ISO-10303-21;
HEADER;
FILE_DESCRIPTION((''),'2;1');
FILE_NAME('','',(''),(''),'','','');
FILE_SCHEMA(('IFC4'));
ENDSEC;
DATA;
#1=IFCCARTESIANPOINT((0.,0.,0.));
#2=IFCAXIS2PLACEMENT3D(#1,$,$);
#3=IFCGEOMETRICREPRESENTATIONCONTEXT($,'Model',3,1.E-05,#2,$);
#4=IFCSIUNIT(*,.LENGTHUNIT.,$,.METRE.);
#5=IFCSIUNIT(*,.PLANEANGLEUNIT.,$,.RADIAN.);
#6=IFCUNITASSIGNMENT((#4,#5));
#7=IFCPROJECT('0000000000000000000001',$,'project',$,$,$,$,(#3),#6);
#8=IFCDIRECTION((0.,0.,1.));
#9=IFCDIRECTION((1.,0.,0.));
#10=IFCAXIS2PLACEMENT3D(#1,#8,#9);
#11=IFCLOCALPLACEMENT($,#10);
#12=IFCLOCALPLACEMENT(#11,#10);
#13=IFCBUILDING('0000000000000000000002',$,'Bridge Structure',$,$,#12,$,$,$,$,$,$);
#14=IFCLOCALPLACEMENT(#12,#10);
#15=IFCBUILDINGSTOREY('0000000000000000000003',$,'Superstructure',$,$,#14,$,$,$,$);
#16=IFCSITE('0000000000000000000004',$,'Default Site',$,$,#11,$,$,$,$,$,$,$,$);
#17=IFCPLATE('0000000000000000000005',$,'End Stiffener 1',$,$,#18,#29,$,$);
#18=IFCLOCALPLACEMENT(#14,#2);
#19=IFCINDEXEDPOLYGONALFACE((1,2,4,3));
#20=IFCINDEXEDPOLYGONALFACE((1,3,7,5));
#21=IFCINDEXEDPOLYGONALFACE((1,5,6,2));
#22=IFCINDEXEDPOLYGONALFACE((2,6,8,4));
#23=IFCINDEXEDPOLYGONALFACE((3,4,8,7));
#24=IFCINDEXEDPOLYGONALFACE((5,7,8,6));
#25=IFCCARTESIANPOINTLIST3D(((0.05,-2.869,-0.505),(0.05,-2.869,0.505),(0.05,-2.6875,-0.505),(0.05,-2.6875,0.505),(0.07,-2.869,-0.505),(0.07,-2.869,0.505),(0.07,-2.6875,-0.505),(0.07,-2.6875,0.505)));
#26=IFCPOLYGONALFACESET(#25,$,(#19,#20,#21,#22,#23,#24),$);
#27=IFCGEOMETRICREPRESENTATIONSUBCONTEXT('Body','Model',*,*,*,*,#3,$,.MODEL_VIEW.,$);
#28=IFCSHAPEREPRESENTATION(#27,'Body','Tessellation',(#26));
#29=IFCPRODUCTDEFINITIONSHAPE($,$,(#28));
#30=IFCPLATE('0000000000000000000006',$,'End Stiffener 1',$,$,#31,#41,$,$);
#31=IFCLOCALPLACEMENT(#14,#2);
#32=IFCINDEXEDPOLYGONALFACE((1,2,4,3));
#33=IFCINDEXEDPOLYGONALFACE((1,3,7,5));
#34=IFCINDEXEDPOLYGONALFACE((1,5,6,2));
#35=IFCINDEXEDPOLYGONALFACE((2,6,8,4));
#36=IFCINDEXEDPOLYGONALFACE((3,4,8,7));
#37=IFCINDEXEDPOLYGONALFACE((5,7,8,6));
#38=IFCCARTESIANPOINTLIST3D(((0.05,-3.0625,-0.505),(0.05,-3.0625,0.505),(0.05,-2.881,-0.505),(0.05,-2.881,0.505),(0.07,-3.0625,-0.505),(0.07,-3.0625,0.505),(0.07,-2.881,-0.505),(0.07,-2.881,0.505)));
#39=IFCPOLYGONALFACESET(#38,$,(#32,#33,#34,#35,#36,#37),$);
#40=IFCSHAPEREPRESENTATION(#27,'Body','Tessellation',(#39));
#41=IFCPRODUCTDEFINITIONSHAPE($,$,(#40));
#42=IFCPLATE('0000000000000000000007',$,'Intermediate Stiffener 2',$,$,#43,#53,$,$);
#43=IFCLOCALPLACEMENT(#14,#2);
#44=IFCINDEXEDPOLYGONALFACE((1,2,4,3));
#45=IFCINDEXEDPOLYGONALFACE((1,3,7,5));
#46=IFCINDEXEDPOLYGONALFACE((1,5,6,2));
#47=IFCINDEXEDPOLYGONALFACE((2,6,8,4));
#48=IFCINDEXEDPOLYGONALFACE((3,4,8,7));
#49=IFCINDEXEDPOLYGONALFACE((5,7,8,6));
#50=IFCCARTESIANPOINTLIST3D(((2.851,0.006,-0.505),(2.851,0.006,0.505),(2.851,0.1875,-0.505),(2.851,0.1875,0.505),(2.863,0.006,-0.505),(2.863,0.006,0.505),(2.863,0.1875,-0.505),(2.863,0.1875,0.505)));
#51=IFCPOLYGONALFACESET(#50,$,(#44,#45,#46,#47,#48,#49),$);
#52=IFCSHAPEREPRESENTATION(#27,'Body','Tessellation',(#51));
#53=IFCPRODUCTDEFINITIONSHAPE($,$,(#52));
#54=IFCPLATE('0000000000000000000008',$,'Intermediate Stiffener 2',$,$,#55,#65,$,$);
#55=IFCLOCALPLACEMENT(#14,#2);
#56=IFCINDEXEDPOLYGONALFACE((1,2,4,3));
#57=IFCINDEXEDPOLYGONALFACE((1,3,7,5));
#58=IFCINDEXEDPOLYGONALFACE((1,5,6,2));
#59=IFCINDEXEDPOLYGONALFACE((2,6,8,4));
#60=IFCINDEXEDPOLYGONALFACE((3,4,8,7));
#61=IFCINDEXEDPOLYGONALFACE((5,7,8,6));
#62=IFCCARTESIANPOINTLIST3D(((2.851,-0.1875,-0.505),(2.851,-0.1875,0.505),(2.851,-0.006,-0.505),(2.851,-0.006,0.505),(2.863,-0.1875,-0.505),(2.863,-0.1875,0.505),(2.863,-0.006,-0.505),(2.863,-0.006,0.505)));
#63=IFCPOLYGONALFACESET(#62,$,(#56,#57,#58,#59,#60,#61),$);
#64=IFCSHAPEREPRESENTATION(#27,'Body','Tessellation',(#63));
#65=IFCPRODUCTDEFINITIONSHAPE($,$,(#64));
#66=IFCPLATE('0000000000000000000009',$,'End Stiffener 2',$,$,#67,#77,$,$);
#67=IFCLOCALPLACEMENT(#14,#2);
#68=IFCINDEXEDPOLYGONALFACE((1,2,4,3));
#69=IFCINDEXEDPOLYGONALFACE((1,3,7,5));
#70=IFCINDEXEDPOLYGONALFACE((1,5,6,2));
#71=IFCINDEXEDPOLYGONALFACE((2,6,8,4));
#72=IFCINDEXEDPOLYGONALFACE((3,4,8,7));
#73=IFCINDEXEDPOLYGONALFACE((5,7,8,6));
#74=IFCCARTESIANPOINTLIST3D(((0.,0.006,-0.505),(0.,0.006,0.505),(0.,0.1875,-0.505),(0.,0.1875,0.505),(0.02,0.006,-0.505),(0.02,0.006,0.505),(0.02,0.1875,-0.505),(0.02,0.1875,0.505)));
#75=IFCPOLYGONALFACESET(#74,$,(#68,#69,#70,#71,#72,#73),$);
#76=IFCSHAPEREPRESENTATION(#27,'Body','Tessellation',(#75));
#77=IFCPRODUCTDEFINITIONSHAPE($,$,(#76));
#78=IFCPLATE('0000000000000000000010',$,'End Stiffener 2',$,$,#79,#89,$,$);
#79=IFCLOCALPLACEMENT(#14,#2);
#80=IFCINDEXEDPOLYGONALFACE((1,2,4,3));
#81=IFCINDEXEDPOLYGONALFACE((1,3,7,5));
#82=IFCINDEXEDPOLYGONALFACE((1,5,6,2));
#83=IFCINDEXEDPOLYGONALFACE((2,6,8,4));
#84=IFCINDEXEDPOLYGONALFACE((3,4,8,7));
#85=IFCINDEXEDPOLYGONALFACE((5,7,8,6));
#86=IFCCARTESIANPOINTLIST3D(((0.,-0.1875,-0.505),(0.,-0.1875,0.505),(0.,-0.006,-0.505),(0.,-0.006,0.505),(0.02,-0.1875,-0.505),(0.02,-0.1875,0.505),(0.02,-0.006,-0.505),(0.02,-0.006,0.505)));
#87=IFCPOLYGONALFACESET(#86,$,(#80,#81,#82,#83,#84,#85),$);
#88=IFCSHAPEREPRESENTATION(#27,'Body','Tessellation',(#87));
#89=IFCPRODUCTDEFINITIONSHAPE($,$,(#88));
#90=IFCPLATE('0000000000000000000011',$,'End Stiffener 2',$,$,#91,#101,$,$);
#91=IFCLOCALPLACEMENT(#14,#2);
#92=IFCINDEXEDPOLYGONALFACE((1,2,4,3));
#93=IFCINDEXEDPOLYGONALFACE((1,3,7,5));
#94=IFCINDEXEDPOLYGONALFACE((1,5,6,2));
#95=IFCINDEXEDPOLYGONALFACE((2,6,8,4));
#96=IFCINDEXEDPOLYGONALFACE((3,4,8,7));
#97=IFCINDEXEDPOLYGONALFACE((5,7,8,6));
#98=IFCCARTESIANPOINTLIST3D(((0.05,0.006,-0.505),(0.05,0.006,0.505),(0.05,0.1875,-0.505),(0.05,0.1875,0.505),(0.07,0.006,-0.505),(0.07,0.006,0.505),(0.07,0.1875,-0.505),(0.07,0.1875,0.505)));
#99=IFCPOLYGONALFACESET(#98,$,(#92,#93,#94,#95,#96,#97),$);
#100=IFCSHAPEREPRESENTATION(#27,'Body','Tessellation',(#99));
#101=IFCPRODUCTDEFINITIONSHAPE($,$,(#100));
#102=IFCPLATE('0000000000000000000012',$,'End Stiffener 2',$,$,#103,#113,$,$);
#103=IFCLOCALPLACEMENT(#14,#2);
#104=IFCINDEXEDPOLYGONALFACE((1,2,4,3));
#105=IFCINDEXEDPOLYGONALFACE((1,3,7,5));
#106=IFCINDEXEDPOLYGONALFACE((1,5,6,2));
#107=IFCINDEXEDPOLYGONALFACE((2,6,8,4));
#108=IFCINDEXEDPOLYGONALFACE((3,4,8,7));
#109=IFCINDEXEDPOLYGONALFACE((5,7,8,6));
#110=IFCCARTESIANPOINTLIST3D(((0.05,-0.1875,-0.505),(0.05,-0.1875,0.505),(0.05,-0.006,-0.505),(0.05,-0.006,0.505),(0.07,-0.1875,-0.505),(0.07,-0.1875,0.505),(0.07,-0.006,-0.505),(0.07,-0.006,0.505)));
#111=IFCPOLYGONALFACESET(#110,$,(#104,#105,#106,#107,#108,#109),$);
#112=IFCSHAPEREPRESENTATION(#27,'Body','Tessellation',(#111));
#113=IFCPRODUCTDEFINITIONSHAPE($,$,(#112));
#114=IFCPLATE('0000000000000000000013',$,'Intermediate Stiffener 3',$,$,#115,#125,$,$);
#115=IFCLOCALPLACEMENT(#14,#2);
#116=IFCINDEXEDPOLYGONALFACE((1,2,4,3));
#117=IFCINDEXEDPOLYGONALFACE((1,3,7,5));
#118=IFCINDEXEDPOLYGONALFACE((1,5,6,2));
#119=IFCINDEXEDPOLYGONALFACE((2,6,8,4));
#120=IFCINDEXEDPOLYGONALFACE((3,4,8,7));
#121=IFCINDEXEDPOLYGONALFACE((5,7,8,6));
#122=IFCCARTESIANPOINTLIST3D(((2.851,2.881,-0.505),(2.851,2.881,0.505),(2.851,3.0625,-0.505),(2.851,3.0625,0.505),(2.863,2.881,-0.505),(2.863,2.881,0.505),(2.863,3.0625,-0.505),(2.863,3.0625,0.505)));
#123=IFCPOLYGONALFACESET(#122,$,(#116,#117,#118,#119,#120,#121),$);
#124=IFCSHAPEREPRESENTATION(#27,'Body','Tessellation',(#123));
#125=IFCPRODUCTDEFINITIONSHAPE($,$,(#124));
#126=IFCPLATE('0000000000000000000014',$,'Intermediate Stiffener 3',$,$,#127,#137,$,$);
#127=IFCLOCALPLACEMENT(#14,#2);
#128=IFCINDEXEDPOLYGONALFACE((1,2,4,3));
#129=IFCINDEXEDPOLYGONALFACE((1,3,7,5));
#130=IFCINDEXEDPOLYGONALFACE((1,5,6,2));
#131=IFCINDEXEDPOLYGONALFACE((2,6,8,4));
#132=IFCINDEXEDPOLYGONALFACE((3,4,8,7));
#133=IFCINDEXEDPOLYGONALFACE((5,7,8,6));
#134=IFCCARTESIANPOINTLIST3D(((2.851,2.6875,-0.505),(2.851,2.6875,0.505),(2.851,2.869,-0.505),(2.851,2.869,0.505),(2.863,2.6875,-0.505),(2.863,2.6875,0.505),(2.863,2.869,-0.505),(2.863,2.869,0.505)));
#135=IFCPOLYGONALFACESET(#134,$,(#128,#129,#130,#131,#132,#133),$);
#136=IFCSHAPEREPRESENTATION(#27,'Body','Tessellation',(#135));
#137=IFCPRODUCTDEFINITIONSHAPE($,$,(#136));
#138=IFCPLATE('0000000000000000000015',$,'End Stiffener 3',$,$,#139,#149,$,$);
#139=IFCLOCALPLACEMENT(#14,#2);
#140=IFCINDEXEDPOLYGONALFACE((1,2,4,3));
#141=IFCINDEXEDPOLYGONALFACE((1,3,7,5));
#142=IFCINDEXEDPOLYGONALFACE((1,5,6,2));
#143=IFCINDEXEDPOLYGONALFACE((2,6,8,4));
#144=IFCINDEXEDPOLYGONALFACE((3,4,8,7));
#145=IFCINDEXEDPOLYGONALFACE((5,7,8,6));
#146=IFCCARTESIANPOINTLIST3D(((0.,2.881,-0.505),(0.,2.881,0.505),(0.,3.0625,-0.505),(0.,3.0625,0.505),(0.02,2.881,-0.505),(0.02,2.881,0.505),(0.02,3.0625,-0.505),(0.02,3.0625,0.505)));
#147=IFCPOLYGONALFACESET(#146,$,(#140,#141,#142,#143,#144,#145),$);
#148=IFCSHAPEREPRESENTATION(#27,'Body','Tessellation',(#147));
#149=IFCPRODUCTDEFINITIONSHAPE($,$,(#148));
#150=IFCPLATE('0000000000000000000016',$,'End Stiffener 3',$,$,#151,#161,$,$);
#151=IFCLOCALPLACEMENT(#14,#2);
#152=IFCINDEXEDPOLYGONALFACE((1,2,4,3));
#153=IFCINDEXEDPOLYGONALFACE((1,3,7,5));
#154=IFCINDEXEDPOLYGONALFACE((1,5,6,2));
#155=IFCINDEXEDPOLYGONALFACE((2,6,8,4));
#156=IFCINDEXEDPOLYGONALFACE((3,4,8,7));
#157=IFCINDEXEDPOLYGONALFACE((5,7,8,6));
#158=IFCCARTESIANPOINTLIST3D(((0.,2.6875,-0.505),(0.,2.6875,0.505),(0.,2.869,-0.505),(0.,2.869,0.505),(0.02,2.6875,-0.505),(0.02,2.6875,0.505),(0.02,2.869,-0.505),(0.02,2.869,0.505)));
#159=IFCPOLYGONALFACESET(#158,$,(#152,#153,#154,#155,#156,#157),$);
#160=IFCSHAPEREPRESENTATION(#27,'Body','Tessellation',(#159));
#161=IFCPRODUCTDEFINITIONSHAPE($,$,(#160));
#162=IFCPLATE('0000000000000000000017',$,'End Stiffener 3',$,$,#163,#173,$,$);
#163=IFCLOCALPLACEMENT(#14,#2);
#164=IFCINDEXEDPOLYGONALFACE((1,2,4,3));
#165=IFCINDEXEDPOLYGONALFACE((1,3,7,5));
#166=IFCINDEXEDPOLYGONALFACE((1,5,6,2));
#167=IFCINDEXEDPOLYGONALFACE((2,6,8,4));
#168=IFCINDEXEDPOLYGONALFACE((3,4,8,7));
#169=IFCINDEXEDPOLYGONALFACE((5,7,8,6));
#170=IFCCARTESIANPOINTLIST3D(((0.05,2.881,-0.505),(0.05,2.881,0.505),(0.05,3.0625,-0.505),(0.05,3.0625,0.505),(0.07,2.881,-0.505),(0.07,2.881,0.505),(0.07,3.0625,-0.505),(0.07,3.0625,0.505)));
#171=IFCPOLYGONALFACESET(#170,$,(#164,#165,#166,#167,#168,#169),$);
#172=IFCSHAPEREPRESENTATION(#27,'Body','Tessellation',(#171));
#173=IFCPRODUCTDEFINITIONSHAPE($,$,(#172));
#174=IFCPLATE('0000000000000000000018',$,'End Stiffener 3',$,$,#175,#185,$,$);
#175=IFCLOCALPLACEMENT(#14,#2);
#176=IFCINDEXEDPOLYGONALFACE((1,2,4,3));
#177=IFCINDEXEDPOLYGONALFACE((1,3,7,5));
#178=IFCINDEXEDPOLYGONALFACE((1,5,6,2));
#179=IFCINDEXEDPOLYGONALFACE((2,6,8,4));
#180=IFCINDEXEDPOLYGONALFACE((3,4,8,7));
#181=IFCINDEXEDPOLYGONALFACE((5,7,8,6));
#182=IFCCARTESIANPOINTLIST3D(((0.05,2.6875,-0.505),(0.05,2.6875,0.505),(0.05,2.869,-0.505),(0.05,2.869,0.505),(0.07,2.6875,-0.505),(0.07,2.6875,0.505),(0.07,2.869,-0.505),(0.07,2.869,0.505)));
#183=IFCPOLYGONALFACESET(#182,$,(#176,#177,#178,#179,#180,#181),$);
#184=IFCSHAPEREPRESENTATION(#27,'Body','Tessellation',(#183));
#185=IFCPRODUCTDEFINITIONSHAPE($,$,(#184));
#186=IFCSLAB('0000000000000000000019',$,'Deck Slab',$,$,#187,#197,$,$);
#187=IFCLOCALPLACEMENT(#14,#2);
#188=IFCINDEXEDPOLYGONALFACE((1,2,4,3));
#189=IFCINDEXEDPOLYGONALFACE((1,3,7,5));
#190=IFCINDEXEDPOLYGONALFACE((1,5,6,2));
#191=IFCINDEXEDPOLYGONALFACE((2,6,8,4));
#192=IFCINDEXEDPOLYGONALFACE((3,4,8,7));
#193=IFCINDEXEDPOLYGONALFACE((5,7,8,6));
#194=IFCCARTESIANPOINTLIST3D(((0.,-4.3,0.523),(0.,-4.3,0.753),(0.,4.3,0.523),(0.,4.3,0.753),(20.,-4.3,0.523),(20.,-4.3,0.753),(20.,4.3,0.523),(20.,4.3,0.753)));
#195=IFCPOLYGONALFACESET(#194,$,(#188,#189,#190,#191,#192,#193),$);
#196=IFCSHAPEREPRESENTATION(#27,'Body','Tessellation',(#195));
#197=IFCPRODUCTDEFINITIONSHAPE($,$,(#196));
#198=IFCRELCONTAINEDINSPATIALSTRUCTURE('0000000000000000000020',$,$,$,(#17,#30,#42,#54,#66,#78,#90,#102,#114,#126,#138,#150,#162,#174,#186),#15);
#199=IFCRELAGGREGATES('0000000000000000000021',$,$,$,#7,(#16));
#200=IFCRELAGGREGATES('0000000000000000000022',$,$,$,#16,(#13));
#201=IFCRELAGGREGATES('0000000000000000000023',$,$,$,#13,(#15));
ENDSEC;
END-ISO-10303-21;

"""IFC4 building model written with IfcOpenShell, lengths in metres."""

from ifc_helpers import new_model, si_unit, frame, origin, origin_with_axes, origin_2d_with_axis, place, context, subcontext, project, spatial, polyline, rectangle, outline, extrude, element, save


model = new_model("IFC4")

# Units and contexts
model_context = context("Model", 3, precision=1e-05, world=origin())
body_context = subcontext(model_context, "Body", "Model", "MODEL_VIEW")
ifc_project = project(units=[si_unit("LENGTHUNIT", "METRE"), si_unit("PLANEANGLEUNIT", "RADIAN")], contexts=[model_context])

# Site, building, storey
site_placement = place(None, origin_with_axes())
site = spatial("IfcSite", under=ifc_project, at=site_placement, Name="Default Site")
building_placement = place(site_placement, origin_with_axes())
building = spatial("IfcBuilding", under=site, at=building_placement, Name="Bridge Structure")
storey_placement = place(building_placement, origin_with_axes())
storey = spatial("IfcBuildingStorey", under=building, at=storey_placement, Name="Superstructure")

# Plates
for number, where, z_axis, x_axis, name in (
    (1, (0.06, -2.7782, -0.505), (0.0, 0.0, 1.0), (1.0, 0.0, 0.0), "End Stiffener 1"),
    (2, (0.06, -2.9718, -0.505), (0.0, 0.0, 1.0), (1.0, 0.0, 0.0), "End Stiffener 1"),
):
    element("IfcPlate", number, at=place(storey_placement, frame(where, z_axis=z_axis, x_axis=x_axis)), inside=storey, Name=name, context=body_context, shape_type="SweptSolid", body=[
        extrude(rectangle(XDim=0.02, YDim=0.1815, at=origin_2d_with_axis()), origin_with_axes(), (0.0, 0.0, 1.0), 1.01),
    ])
for number, where, z_axis, x_axis, name in (
    (3, (2.857, 0.0968, -0.505), (0.0, 0.0, 1.0), (1.0, 0.0, 0.0), "Intermediate Stiffener 2"),
    (4, (2.857, -0.0968, -0.505), (0.0, 0.0, 1.0), (1.0, 0.0, 0.0), "Intermediate Stiffener 2"),
):
    element("IfcPlate", number, at=place(storey_placement, frame(where, z_axis=z_axis, x_axis=x_axis)), inside=storey, Name=name, context=body_context, shape_type="SweptSolid", body=[
        extrude(rectangle(XDim=0.012, YDim=0.1815, at=origin_2d_with_axis()), origin_with_axes(), (0.0, 0.0, 1.0), 1.01),
    ])
for number, where, z_axis, x_axis, name in (
    (5, (0.01, 0.0968, -0.505), (0.0, 0.0, 1.0), (1.0, 0.0, 0.0), "End Stiffener 2"),
    (6, (0.01, -0.0968, -0.505), (0.0, 0.0, 1.0), (1.0, 0.0, 0.0), "End Stiffener 2"),
    (7, (0.06, 0.0968, -0.505), (0.0, 0.0, 1.0), (1.0, 0.0, 0.0), "End Stiffener 2"),
    (8, (0.06, -0.0968, -0.505), (0.0, 0.0, 1.0), (1.0, 0.0, 0.0), "End Stiffener 2"),
):
    element("IfcPlate", number, at=place(storey_placement, frame(where, z_axis=z_axis, x_axis=x_axis)), inside=storey, Name=name, context=body_context, shape_type="SweptSolid", body=[
        extrude(rectangle(XDim=0.02, YDim=0.1815, at=origin_2d_with_axis()), origin_with_axes(), (0.0, 0.0, 1.0), 1.01),
    ])
for number, where, z_axis, x_axis, name in (
    (9, (2.857, 2.9718, -0.505), (0.0, 0.0, 1.0), (1.0, 0.0, 0.0), "Intermediate Stiffener 3"),
    (10, (2.857, 2.7782, -0.505), (0.0, 0.0, 1.0), (1.0, 0.0, 0.0), "Intermediate Stiffener 3"),
):
    element("IfcPlate", number, at=place(storey_placement, frame(where, z_axis=z_axis, x_axis=x_axis)), inside=storey, Name=name, context=body_context, shape_type="SweptSolid", body=[
        extrude(rectangle(XDim=0.012, YDim=0.1815, at=origin_2d_with_axis()), origin_with_axes(), (0.0, 0.0, 1.0), 1.01),
    ])
for number, where, z_axis, x_axis, name in (
    (11, (0.01, 2.9718, -0.505), (0.0, 0.0, 1.0), (1.0, 0.0, 0.0), "End Stiffener 3"),
    (12, (0.01, 2.7782, -0.505), (0.0, 0.0, 1.0), (1.0, 0.0, 0.0), "End Stiffener 3"),
    (13, (0.06, 2.9718, -0.505), (0.0, 0.0, 1.0), (1.0, 0.0, 0.0), "End Stiffener 3"),
    (14, (0.06, 2.7782, -0.505), (0.0, 0.0, 1.0), (1.0, 0.0, 0.0), "End Stiffener 3"),
):
    element("IfcPlate", number, at=place(storey_placement, frame(where, z_axis=z_axis, x_axis=x_axis)), inside=storey, Name=name, context=body_context, shape_type="SweptSolid", body=[
        extrude(rectangle(XDim=0.02, YDim=0.1815, at=origin_2d_with_axis()), origin_with_axes(), (0.0, 0.0, 1.0), 1.01),
    ])

# Slab
slab_placement = place(storey_placement, frame((0.0, 0.0, 0.523), z_axis=(0.0, 0.0, 1.0), x_axis=(1.0, 0.0, 0.0)))
element("IfcSlab", 15, at=slab_placement, inside=storey, Name="Deck Slab", context=body_context, shape_type="SweptSolid", body=[
    extrude(outline(polyline([(0.0, -4.3), (20.0, -4.3), (20.0, 4.3), (0.0, 4.3), (0.0, -4.3)])), origin_with_axes(), (0.0, 0.0, 1.0), 0.23),
])

save(model, "model.ifc")
